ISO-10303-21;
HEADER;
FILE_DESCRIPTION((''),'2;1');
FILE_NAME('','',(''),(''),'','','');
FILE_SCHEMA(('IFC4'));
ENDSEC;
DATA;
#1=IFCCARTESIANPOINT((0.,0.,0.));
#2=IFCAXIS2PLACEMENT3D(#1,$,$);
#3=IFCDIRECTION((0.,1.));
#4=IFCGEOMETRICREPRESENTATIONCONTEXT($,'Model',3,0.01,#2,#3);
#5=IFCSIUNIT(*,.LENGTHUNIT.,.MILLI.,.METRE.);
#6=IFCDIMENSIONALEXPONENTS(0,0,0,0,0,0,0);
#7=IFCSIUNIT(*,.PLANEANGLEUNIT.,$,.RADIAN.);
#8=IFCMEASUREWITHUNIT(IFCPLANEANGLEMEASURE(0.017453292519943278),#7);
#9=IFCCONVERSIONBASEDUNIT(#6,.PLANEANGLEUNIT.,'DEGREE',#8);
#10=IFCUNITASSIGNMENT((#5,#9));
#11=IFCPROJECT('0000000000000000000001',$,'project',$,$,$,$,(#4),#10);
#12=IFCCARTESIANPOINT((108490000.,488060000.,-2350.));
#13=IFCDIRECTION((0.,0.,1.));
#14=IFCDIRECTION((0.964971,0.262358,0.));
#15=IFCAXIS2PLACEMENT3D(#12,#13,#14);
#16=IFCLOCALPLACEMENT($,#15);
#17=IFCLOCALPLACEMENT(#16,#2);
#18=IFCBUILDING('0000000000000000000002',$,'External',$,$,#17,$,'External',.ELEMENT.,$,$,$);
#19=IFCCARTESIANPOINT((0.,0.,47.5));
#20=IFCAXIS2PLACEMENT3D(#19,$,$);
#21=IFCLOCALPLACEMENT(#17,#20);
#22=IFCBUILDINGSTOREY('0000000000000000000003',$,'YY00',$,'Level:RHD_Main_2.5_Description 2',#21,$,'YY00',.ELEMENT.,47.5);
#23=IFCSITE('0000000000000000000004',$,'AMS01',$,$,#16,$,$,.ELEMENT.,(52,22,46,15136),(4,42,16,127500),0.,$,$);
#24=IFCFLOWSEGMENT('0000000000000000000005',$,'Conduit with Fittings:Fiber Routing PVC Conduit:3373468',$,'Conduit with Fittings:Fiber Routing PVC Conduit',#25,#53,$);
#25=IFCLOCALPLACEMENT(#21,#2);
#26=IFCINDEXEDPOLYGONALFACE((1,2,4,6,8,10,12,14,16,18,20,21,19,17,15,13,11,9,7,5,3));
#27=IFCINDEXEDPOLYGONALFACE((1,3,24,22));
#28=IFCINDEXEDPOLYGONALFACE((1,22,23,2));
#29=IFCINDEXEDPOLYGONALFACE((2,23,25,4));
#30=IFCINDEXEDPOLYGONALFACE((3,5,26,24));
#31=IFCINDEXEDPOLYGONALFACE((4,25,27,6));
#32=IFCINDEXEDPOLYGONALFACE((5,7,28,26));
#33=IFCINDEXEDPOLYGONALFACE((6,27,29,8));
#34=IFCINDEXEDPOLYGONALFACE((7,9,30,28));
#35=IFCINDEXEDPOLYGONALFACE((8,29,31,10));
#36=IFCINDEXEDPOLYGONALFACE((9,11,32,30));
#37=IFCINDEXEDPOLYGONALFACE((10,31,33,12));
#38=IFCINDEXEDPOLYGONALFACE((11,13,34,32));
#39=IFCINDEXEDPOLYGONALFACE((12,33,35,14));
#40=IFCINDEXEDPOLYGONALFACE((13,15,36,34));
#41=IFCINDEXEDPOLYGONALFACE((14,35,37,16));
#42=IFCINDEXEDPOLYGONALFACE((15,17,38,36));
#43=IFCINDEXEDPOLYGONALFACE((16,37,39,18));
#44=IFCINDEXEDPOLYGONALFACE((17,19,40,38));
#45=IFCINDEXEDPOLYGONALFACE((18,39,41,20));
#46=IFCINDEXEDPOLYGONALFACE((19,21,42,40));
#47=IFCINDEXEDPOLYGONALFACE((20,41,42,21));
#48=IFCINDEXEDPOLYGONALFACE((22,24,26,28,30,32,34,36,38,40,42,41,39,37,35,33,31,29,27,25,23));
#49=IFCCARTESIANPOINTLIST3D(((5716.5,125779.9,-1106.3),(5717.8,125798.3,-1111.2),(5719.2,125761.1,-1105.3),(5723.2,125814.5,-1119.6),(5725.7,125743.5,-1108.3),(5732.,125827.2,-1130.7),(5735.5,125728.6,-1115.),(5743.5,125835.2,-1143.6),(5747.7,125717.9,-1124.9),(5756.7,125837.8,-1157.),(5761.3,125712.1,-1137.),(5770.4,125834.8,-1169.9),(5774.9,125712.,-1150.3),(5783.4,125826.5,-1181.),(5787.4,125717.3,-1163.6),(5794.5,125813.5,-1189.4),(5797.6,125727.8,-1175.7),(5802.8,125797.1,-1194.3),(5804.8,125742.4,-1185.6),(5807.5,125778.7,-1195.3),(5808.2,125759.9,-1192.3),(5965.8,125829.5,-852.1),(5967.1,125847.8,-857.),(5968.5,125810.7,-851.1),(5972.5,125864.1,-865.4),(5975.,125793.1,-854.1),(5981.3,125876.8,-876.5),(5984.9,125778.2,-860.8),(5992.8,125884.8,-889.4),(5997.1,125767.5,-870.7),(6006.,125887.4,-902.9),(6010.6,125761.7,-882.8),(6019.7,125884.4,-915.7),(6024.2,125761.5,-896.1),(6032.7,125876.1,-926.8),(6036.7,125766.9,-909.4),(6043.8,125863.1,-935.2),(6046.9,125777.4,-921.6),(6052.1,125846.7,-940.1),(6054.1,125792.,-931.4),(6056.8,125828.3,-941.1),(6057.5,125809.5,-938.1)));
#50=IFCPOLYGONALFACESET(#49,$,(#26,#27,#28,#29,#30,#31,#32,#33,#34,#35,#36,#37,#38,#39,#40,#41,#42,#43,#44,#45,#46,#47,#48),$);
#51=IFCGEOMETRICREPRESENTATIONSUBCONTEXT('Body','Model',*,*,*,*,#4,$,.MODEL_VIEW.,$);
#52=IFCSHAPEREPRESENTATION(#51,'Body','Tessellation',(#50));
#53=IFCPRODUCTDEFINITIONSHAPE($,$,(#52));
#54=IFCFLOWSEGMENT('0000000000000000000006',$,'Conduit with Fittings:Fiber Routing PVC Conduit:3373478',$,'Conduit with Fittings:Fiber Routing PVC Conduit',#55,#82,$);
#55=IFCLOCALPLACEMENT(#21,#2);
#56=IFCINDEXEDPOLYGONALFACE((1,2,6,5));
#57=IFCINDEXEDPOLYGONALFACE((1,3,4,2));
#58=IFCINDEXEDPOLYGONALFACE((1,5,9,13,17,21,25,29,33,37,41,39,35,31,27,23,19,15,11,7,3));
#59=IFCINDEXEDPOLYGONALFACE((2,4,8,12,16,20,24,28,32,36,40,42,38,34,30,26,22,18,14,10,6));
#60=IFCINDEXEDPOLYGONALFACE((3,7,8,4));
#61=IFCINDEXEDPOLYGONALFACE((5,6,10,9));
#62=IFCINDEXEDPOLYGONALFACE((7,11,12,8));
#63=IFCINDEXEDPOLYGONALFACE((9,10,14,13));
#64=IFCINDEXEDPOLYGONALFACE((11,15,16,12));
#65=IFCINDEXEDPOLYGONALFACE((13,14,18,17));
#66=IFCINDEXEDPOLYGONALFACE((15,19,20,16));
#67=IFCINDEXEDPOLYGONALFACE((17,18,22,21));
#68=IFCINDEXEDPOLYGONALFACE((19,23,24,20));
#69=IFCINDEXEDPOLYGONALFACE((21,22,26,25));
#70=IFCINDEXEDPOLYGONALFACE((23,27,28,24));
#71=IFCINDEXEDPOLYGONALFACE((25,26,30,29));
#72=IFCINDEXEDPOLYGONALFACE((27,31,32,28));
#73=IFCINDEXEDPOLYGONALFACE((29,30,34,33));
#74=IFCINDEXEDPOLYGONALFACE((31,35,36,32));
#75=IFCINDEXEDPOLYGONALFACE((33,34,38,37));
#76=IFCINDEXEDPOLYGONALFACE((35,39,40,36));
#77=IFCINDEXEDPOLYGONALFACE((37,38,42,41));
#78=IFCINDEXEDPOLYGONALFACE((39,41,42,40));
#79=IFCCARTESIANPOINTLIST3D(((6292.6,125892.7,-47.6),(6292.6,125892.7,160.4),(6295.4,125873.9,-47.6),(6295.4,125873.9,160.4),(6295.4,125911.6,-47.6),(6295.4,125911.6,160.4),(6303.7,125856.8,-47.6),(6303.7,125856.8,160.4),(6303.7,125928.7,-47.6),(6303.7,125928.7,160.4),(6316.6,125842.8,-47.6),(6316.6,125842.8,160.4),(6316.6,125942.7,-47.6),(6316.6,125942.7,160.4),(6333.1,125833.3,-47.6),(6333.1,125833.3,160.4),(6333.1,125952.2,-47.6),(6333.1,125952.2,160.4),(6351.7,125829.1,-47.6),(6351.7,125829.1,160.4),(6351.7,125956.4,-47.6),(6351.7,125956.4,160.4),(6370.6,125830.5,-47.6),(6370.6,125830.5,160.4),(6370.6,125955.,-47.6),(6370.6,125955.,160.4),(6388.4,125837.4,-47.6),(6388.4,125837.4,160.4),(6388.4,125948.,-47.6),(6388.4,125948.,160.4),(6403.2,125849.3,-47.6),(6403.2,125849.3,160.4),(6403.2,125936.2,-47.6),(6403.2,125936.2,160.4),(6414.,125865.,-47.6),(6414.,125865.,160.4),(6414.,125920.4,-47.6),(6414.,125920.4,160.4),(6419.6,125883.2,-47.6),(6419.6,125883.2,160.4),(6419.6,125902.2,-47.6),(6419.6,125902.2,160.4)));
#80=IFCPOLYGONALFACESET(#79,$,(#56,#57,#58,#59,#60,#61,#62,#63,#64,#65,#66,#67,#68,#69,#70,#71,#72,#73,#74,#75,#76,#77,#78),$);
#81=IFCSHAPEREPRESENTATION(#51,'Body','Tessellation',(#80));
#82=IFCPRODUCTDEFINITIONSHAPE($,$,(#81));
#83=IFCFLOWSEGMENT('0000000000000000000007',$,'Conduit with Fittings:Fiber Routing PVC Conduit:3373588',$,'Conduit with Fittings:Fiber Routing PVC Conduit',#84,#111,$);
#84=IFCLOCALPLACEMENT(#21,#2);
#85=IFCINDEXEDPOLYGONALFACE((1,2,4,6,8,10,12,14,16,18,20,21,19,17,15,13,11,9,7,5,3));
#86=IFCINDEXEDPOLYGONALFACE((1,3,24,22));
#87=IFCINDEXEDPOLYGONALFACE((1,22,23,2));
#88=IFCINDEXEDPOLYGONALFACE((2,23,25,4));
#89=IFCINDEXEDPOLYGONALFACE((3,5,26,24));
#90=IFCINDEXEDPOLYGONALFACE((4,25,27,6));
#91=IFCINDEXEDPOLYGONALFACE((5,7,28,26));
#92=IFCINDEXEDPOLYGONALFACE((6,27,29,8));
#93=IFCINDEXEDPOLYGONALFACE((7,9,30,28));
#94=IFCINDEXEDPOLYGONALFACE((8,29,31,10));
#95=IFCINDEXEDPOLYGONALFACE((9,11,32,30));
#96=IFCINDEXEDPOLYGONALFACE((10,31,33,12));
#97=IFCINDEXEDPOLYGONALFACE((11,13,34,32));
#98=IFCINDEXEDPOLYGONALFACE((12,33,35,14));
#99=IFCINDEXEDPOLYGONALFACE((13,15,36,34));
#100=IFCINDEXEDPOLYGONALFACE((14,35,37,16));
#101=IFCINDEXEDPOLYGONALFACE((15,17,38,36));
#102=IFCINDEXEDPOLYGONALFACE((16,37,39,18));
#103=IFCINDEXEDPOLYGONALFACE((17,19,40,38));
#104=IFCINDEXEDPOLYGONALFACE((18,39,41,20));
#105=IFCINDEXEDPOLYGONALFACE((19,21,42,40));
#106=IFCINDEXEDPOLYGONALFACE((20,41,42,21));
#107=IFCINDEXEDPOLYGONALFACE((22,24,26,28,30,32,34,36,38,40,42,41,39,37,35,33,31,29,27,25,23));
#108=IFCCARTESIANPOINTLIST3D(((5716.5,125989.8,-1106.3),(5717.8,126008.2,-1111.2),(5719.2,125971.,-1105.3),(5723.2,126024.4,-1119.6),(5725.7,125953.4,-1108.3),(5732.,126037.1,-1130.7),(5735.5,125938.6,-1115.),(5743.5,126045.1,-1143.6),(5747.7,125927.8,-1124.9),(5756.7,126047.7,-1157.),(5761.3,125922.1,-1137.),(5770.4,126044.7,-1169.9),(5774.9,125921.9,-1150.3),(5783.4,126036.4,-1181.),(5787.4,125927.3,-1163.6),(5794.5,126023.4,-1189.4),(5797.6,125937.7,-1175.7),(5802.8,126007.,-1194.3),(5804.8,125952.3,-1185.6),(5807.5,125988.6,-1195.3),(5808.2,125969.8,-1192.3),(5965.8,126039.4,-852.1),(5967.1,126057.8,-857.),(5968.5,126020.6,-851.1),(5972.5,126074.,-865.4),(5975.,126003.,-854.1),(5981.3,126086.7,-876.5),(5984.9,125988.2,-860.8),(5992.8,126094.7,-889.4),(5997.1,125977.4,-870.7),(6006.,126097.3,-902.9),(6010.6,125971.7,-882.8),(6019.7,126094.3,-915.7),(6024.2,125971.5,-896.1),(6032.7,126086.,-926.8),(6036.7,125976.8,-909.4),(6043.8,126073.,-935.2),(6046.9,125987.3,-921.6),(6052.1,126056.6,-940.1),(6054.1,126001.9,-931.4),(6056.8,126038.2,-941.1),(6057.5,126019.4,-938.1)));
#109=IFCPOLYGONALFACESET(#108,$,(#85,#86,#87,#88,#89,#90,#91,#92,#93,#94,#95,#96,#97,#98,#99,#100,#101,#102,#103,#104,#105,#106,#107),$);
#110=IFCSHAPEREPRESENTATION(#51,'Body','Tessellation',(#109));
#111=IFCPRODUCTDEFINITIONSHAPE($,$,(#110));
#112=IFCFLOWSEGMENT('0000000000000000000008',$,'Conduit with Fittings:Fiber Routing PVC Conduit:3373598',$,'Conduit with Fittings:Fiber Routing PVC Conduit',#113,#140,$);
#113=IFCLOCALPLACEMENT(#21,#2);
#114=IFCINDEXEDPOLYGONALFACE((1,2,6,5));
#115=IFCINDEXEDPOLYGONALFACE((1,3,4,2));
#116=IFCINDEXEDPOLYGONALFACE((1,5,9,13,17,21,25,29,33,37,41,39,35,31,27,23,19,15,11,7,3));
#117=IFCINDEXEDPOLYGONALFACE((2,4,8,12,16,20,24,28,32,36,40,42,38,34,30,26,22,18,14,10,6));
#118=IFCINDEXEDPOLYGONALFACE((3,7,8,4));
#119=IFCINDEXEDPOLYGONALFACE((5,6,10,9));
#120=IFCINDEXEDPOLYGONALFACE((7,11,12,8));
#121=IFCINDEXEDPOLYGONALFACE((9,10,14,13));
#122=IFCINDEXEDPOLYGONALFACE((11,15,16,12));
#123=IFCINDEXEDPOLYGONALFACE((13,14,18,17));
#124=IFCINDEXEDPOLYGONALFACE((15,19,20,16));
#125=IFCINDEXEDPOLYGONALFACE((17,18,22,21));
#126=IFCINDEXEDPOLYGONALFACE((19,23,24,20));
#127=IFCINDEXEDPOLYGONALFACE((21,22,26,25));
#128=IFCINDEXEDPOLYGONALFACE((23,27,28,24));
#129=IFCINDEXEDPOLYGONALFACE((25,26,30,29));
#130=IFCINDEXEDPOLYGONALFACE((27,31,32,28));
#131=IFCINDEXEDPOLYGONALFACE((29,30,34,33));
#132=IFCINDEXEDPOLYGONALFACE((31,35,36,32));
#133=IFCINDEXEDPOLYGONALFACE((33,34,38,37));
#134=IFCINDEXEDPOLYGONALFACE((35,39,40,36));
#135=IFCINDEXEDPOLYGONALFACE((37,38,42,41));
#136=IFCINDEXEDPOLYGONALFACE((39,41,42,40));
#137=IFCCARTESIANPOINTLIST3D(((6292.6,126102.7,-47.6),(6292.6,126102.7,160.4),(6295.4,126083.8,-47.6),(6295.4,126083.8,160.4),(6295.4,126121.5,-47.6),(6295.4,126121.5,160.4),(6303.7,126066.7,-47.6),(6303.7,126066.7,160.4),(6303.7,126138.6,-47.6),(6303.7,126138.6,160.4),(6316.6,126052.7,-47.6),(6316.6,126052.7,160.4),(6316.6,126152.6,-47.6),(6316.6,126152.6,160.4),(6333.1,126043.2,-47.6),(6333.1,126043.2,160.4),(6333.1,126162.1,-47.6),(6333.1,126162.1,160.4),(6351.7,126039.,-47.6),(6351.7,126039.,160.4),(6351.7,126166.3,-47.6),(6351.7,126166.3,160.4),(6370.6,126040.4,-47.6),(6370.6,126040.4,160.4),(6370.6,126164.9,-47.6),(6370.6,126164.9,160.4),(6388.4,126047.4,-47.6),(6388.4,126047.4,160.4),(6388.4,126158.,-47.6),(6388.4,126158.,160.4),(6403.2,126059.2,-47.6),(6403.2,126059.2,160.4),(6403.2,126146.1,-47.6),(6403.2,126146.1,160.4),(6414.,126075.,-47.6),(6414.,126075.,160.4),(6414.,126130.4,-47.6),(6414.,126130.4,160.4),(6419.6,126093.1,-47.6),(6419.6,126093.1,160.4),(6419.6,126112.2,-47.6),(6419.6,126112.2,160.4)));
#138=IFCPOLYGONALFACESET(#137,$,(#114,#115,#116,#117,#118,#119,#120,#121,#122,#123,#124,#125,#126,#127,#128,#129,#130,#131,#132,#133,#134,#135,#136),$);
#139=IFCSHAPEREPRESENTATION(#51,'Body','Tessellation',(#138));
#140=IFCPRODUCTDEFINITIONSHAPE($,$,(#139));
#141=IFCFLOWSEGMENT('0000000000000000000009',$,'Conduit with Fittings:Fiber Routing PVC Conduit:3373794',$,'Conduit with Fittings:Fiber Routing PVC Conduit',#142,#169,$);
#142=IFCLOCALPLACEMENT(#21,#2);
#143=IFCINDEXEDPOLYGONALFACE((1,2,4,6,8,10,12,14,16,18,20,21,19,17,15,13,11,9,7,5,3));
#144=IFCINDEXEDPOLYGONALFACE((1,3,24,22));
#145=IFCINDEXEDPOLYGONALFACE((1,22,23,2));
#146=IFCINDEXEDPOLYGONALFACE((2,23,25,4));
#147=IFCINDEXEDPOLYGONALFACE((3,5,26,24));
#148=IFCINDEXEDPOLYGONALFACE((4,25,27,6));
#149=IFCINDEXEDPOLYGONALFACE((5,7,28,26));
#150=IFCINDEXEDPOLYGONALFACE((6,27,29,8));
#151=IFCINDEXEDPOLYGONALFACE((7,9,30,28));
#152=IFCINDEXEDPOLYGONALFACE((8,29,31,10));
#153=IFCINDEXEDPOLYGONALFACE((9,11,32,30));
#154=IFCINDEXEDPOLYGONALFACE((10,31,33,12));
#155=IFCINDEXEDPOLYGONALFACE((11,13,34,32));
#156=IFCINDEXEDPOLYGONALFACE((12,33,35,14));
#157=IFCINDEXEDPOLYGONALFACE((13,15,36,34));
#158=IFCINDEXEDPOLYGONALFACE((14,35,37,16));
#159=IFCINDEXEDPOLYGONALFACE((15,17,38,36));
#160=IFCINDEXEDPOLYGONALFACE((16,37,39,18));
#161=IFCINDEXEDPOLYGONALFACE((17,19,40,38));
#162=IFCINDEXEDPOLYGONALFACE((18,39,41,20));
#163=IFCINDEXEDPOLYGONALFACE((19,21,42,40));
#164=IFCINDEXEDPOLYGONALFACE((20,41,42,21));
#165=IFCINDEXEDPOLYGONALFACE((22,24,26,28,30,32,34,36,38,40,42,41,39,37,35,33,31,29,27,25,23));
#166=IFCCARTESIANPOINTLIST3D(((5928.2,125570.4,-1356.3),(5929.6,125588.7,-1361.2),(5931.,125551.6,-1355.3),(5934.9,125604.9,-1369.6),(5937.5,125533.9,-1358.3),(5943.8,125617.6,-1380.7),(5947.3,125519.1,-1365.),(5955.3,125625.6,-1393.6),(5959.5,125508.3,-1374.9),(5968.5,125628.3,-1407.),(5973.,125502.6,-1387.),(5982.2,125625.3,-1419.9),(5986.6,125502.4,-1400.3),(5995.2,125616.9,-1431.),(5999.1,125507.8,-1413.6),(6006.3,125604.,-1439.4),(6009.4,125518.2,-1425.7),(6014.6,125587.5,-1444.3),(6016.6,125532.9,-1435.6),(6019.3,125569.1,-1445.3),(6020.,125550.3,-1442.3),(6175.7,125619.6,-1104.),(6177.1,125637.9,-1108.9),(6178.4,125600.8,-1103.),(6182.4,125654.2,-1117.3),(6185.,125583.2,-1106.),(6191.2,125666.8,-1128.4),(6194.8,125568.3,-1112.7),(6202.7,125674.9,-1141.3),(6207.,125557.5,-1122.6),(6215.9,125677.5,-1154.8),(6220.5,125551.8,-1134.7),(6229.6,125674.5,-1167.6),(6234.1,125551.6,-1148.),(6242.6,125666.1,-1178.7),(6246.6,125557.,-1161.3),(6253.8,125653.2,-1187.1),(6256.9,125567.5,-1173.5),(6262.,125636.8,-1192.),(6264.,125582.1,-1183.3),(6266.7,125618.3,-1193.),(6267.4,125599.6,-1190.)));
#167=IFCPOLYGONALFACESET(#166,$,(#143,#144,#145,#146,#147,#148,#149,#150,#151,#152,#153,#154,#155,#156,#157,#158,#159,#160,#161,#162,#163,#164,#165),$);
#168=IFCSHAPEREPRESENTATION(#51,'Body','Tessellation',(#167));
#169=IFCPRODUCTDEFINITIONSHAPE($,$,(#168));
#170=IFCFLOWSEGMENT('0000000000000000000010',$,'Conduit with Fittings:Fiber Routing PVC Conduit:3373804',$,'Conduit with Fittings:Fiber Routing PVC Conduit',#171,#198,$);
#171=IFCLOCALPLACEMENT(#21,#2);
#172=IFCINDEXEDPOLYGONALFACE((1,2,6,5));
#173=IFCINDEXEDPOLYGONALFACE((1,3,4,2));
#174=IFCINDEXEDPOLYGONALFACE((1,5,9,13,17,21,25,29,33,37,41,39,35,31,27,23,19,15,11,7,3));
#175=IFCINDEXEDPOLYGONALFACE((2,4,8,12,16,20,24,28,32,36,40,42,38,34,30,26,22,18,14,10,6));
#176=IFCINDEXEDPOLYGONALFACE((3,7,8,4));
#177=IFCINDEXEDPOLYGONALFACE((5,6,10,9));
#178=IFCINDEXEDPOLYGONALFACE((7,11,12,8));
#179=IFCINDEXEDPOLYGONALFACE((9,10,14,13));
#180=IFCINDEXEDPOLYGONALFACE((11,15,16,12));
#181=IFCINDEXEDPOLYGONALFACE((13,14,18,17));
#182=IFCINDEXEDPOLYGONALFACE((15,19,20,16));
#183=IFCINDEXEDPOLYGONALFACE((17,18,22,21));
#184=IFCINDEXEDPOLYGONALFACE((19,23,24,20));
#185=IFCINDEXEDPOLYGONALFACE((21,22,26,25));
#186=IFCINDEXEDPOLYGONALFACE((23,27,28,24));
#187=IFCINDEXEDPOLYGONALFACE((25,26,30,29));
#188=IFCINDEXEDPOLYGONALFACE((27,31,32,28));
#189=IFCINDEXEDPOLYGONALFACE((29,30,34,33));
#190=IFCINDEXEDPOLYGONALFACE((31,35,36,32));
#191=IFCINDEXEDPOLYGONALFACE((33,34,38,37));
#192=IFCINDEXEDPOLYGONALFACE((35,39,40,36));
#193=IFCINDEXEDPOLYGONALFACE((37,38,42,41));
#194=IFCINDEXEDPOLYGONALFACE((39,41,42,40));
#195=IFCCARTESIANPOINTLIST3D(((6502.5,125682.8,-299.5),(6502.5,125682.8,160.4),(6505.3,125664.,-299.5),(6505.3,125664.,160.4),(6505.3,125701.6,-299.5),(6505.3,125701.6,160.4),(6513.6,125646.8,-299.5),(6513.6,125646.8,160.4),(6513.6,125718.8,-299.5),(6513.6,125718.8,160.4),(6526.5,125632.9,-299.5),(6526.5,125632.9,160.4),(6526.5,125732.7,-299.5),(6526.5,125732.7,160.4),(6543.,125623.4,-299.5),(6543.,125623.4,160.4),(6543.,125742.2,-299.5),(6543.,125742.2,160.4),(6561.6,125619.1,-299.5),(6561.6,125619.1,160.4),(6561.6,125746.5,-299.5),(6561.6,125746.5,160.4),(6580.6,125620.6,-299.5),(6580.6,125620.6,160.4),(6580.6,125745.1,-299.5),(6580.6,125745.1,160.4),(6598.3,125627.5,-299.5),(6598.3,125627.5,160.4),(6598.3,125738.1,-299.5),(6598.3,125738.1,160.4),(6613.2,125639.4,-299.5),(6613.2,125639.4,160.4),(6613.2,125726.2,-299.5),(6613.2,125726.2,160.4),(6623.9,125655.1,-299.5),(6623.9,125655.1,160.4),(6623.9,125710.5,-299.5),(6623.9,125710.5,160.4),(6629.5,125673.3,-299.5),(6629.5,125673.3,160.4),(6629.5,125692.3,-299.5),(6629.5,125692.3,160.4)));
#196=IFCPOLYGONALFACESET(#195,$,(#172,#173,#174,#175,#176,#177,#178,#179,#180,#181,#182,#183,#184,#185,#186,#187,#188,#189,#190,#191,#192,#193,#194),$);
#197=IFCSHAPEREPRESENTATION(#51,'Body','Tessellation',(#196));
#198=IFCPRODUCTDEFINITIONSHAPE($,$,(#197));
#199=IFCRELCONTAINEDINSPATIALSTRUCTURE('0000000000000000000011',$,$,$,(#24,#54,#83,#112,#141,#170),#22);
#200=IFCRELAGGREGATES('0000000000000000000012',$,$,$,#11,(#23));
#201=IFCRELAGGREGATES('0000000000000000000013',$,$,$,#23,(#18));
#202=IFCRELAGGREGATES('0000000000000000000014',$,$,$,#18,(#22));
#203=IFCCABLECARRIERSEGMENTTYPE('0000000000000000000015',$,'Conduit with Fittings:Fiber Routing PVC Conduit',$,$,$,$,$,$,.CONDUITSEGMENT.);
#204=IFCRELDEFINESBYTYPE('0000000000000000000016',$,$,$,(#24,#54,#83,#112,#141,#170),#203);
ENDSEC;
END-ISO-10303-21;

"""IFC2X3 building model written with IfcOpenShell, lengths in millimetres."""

from ifc_helpers import new_model, entity, si_unit, converted_unit, direction, frame, frame_2d, origin, origin_2d_with_axis, place, context, subcontext, project, spatial, circle, extrude, type_object, element, save


model = new_model("IFC2X3")

# Units and contexts
model_context = context("Model", 3, precision=0.01, world=origin(), true_north=direction((0.0, 1.0)))
body_context = subcontext(model_context, "Body", "Model", "MODEL_VIEW")
ifc_project = project(units=[si_unit("LENGTHUNIT", "METRE", prefix="MILLI"), converted_unit("PLANEANGLEUNIT", "DEGREE", entity("IfcPlaneAngleMeasure", 0.017453292519943278), si_unit("PLANEANGLEUNIT", "RADIAN"), dimensions=[0, 0, 0, 0, 0, 0, 0])], contexts=[model_context])

# Site, building, storey
site_placement = place(None, frame((108490000.0, 488060000.0, -2350.0), z_axis=(0.0, 0.0, 1.0), x_axis=(0.964971, 0.262358, 0.0)))
site = spatial("IfcSite", under=ifc_project, at=site_placement, Name="AMS01", CompositionType="ELEMENT", RefLatitude=(52, 22, 46, 15136), RefLongitude=(4, 42, 16, 127500), RefElevation=0.0)
building_placement = place(site_placement, origin())
building = spatial("IfcBuilding", under=site, at=building_placement, Name="External", LongName="External", CompositionType="ELEMENT")
storey_placement = place(building_placement, frame((0.0, 0.0, 47.5)))
storey = spatial("IfcBuildingStorey", under=building, at=storey_placement, Name="YY00", ObjectType="Level:RHD_Main_2.5_Description 2", LongName="YY00", CompositionType="ELEMENT", Elevation=47.5)

# Flow segments
cable_carrier_segment_type = type_object("IfcCableCarrierSegmentType", Name="Conduit with Fittings:Fiber Routing PVC Conduit", PredefinedType="CONDUITSEGMENT")
flow_segment_1_placement = place(storey_placement, origin())
element("IfcFlowSegment", 1, at=flow_segment_1_placement, inside=storey, type_object=cable_carrier_segment_type, Name="Conduit with Fittings:Fiber Routing PVC Conduit:3373468", ObjectType="Conduit with Fittings:Fiber Routing PVC Conduit", context=body_context, shape_type="SweptSolid", body=[
    extrude(circle(Radius=63.9, at=frame_2d((0.0, 0.0), x_axis=(1.0, 0.0))), frame((5762.4, 125774.6, -1150.3), z_axis=(0.69352, 0.13795, 0.707107), x_axis=(0.19509, -0.980785, 0.0)), (0.0, 0.0, 1.0), 359.5),
])
flow_segment_2_placement = place(storey_placement, origin())
element("IfcFlowSegment", 2, at=flow_segment_2_placement, inside=storey, type_object=cable_carrier_segment_type, Name="Conduit with Fittings:Fiber Routing PVC Conduit:3373478", ObjectType="Conduit with Fittings:Fiber Routing PVC Conduit", context=body_context, shape_type="SweptSolid", body=[
    extrude(circle(Radius=63.9, at=origin_2d_with_axis()), frame((6356.4, 125892.7, -47.6), z_axis=(0.0, 0.0, 1.0), x_axis=(-1.0, 0.0, 0.0)), (0.0, 0.0, 1.0), 207.9),
])
flow_segment_3_placement = place(storey_placement, origin())
element("IfcFlowSegment", 3, at=flow_segment_3_placement, inside=storey, type_object=cable_carrier_segment_type, Name="Conduit with Fittings:Fiber Routing PVC Conduit:3373588", ObjectType="Conduit with Fittings:Fiber Routing PVC Conduit", context=body_context, shape_type="SweptSolid", body=[
    extrude(circle(Radius=63.9, at=frame_2d((0.0, 0.0), x_axis=(1.0, 0.0))), frame((5762.4, 125984.5, -1150.3), z_axis=(0.69352, 0.13795, 0.707107), x_axis=(0.19509, -0.980785, 0.0)), (0.0, 0.0, 1.0), 359.5),
])
flow_segment_4_placement = place(storey_placement, origin())
element("IfcFlowSegment", 4, at=flow_segment_4_placement, inside=storey, type_object=cable_carrier_segment_type, Name="Conduit with Fittings:Fiber Routing PVC Conduit:3373598", ObjectType="Conduit with Fittings:Fiber Routing PVC Conduit", context=body_context, shape_type="SweptSolid", body=[
    extrude(circle(Radius=63.9, at=origin_2d_with_axis()), frame((6356.4, 126102.7, -47.6), z_axis=(0.0, 0.0, 1.0), x_axis=(-1.0, 0.0, 0.0)), (0.0, 0.0, 1.0), 207.9),
])
flow_segment_5_placement = place(storey_placement, origin())
element("IfcFlowSegment", 5, at=flow_segment_5_placement, inside=storey, type_object=cable_carrier_segment_type, Name="Conduit with Fittings:Fiber Routing PVC Conduit:3373794", ObjectType="Conduit with Fittings:Fiber Routing PVC Conduit", context=body_context, shape_type="SweptSolid", body=[
    extrude(circle(Radius=63.9, at=origin_2d_with_axis()), frame((5974.2, 125565.0, -1400.3), z_axis=(0.69352, 0.13795, 0.707107), x_axis=(0.19509, -0.980785, 0.0)), (0.0, 0.0, 1.0), 356.8),
])
flow_segment_6_placement = place(storey_placement, origin())
element("IfcFlowSegment", 6, at=flow_segment_6_placement, inside=storey, type_object=cable_carrier_segment_type, Name="Conduit with Fittings:Fiber Routing PVC Conduit:3373804", ObjectType="Conduit with Fittings:Fiber Routing PVC Conduit", context=body_context, shape_type="SweptSolid", body=[
    extrude(circle(Radius=63.9, at=origin_2d_with_axis()), frame((6566.4, 125682.8, -299.5), z_axis=(0.0, 0.0, 1.0), x_axis=(-1.0, 0.0, 0.0)), (0.0, 0.0, 1.0), 459.8),
])

save(model, "model.ifc")
